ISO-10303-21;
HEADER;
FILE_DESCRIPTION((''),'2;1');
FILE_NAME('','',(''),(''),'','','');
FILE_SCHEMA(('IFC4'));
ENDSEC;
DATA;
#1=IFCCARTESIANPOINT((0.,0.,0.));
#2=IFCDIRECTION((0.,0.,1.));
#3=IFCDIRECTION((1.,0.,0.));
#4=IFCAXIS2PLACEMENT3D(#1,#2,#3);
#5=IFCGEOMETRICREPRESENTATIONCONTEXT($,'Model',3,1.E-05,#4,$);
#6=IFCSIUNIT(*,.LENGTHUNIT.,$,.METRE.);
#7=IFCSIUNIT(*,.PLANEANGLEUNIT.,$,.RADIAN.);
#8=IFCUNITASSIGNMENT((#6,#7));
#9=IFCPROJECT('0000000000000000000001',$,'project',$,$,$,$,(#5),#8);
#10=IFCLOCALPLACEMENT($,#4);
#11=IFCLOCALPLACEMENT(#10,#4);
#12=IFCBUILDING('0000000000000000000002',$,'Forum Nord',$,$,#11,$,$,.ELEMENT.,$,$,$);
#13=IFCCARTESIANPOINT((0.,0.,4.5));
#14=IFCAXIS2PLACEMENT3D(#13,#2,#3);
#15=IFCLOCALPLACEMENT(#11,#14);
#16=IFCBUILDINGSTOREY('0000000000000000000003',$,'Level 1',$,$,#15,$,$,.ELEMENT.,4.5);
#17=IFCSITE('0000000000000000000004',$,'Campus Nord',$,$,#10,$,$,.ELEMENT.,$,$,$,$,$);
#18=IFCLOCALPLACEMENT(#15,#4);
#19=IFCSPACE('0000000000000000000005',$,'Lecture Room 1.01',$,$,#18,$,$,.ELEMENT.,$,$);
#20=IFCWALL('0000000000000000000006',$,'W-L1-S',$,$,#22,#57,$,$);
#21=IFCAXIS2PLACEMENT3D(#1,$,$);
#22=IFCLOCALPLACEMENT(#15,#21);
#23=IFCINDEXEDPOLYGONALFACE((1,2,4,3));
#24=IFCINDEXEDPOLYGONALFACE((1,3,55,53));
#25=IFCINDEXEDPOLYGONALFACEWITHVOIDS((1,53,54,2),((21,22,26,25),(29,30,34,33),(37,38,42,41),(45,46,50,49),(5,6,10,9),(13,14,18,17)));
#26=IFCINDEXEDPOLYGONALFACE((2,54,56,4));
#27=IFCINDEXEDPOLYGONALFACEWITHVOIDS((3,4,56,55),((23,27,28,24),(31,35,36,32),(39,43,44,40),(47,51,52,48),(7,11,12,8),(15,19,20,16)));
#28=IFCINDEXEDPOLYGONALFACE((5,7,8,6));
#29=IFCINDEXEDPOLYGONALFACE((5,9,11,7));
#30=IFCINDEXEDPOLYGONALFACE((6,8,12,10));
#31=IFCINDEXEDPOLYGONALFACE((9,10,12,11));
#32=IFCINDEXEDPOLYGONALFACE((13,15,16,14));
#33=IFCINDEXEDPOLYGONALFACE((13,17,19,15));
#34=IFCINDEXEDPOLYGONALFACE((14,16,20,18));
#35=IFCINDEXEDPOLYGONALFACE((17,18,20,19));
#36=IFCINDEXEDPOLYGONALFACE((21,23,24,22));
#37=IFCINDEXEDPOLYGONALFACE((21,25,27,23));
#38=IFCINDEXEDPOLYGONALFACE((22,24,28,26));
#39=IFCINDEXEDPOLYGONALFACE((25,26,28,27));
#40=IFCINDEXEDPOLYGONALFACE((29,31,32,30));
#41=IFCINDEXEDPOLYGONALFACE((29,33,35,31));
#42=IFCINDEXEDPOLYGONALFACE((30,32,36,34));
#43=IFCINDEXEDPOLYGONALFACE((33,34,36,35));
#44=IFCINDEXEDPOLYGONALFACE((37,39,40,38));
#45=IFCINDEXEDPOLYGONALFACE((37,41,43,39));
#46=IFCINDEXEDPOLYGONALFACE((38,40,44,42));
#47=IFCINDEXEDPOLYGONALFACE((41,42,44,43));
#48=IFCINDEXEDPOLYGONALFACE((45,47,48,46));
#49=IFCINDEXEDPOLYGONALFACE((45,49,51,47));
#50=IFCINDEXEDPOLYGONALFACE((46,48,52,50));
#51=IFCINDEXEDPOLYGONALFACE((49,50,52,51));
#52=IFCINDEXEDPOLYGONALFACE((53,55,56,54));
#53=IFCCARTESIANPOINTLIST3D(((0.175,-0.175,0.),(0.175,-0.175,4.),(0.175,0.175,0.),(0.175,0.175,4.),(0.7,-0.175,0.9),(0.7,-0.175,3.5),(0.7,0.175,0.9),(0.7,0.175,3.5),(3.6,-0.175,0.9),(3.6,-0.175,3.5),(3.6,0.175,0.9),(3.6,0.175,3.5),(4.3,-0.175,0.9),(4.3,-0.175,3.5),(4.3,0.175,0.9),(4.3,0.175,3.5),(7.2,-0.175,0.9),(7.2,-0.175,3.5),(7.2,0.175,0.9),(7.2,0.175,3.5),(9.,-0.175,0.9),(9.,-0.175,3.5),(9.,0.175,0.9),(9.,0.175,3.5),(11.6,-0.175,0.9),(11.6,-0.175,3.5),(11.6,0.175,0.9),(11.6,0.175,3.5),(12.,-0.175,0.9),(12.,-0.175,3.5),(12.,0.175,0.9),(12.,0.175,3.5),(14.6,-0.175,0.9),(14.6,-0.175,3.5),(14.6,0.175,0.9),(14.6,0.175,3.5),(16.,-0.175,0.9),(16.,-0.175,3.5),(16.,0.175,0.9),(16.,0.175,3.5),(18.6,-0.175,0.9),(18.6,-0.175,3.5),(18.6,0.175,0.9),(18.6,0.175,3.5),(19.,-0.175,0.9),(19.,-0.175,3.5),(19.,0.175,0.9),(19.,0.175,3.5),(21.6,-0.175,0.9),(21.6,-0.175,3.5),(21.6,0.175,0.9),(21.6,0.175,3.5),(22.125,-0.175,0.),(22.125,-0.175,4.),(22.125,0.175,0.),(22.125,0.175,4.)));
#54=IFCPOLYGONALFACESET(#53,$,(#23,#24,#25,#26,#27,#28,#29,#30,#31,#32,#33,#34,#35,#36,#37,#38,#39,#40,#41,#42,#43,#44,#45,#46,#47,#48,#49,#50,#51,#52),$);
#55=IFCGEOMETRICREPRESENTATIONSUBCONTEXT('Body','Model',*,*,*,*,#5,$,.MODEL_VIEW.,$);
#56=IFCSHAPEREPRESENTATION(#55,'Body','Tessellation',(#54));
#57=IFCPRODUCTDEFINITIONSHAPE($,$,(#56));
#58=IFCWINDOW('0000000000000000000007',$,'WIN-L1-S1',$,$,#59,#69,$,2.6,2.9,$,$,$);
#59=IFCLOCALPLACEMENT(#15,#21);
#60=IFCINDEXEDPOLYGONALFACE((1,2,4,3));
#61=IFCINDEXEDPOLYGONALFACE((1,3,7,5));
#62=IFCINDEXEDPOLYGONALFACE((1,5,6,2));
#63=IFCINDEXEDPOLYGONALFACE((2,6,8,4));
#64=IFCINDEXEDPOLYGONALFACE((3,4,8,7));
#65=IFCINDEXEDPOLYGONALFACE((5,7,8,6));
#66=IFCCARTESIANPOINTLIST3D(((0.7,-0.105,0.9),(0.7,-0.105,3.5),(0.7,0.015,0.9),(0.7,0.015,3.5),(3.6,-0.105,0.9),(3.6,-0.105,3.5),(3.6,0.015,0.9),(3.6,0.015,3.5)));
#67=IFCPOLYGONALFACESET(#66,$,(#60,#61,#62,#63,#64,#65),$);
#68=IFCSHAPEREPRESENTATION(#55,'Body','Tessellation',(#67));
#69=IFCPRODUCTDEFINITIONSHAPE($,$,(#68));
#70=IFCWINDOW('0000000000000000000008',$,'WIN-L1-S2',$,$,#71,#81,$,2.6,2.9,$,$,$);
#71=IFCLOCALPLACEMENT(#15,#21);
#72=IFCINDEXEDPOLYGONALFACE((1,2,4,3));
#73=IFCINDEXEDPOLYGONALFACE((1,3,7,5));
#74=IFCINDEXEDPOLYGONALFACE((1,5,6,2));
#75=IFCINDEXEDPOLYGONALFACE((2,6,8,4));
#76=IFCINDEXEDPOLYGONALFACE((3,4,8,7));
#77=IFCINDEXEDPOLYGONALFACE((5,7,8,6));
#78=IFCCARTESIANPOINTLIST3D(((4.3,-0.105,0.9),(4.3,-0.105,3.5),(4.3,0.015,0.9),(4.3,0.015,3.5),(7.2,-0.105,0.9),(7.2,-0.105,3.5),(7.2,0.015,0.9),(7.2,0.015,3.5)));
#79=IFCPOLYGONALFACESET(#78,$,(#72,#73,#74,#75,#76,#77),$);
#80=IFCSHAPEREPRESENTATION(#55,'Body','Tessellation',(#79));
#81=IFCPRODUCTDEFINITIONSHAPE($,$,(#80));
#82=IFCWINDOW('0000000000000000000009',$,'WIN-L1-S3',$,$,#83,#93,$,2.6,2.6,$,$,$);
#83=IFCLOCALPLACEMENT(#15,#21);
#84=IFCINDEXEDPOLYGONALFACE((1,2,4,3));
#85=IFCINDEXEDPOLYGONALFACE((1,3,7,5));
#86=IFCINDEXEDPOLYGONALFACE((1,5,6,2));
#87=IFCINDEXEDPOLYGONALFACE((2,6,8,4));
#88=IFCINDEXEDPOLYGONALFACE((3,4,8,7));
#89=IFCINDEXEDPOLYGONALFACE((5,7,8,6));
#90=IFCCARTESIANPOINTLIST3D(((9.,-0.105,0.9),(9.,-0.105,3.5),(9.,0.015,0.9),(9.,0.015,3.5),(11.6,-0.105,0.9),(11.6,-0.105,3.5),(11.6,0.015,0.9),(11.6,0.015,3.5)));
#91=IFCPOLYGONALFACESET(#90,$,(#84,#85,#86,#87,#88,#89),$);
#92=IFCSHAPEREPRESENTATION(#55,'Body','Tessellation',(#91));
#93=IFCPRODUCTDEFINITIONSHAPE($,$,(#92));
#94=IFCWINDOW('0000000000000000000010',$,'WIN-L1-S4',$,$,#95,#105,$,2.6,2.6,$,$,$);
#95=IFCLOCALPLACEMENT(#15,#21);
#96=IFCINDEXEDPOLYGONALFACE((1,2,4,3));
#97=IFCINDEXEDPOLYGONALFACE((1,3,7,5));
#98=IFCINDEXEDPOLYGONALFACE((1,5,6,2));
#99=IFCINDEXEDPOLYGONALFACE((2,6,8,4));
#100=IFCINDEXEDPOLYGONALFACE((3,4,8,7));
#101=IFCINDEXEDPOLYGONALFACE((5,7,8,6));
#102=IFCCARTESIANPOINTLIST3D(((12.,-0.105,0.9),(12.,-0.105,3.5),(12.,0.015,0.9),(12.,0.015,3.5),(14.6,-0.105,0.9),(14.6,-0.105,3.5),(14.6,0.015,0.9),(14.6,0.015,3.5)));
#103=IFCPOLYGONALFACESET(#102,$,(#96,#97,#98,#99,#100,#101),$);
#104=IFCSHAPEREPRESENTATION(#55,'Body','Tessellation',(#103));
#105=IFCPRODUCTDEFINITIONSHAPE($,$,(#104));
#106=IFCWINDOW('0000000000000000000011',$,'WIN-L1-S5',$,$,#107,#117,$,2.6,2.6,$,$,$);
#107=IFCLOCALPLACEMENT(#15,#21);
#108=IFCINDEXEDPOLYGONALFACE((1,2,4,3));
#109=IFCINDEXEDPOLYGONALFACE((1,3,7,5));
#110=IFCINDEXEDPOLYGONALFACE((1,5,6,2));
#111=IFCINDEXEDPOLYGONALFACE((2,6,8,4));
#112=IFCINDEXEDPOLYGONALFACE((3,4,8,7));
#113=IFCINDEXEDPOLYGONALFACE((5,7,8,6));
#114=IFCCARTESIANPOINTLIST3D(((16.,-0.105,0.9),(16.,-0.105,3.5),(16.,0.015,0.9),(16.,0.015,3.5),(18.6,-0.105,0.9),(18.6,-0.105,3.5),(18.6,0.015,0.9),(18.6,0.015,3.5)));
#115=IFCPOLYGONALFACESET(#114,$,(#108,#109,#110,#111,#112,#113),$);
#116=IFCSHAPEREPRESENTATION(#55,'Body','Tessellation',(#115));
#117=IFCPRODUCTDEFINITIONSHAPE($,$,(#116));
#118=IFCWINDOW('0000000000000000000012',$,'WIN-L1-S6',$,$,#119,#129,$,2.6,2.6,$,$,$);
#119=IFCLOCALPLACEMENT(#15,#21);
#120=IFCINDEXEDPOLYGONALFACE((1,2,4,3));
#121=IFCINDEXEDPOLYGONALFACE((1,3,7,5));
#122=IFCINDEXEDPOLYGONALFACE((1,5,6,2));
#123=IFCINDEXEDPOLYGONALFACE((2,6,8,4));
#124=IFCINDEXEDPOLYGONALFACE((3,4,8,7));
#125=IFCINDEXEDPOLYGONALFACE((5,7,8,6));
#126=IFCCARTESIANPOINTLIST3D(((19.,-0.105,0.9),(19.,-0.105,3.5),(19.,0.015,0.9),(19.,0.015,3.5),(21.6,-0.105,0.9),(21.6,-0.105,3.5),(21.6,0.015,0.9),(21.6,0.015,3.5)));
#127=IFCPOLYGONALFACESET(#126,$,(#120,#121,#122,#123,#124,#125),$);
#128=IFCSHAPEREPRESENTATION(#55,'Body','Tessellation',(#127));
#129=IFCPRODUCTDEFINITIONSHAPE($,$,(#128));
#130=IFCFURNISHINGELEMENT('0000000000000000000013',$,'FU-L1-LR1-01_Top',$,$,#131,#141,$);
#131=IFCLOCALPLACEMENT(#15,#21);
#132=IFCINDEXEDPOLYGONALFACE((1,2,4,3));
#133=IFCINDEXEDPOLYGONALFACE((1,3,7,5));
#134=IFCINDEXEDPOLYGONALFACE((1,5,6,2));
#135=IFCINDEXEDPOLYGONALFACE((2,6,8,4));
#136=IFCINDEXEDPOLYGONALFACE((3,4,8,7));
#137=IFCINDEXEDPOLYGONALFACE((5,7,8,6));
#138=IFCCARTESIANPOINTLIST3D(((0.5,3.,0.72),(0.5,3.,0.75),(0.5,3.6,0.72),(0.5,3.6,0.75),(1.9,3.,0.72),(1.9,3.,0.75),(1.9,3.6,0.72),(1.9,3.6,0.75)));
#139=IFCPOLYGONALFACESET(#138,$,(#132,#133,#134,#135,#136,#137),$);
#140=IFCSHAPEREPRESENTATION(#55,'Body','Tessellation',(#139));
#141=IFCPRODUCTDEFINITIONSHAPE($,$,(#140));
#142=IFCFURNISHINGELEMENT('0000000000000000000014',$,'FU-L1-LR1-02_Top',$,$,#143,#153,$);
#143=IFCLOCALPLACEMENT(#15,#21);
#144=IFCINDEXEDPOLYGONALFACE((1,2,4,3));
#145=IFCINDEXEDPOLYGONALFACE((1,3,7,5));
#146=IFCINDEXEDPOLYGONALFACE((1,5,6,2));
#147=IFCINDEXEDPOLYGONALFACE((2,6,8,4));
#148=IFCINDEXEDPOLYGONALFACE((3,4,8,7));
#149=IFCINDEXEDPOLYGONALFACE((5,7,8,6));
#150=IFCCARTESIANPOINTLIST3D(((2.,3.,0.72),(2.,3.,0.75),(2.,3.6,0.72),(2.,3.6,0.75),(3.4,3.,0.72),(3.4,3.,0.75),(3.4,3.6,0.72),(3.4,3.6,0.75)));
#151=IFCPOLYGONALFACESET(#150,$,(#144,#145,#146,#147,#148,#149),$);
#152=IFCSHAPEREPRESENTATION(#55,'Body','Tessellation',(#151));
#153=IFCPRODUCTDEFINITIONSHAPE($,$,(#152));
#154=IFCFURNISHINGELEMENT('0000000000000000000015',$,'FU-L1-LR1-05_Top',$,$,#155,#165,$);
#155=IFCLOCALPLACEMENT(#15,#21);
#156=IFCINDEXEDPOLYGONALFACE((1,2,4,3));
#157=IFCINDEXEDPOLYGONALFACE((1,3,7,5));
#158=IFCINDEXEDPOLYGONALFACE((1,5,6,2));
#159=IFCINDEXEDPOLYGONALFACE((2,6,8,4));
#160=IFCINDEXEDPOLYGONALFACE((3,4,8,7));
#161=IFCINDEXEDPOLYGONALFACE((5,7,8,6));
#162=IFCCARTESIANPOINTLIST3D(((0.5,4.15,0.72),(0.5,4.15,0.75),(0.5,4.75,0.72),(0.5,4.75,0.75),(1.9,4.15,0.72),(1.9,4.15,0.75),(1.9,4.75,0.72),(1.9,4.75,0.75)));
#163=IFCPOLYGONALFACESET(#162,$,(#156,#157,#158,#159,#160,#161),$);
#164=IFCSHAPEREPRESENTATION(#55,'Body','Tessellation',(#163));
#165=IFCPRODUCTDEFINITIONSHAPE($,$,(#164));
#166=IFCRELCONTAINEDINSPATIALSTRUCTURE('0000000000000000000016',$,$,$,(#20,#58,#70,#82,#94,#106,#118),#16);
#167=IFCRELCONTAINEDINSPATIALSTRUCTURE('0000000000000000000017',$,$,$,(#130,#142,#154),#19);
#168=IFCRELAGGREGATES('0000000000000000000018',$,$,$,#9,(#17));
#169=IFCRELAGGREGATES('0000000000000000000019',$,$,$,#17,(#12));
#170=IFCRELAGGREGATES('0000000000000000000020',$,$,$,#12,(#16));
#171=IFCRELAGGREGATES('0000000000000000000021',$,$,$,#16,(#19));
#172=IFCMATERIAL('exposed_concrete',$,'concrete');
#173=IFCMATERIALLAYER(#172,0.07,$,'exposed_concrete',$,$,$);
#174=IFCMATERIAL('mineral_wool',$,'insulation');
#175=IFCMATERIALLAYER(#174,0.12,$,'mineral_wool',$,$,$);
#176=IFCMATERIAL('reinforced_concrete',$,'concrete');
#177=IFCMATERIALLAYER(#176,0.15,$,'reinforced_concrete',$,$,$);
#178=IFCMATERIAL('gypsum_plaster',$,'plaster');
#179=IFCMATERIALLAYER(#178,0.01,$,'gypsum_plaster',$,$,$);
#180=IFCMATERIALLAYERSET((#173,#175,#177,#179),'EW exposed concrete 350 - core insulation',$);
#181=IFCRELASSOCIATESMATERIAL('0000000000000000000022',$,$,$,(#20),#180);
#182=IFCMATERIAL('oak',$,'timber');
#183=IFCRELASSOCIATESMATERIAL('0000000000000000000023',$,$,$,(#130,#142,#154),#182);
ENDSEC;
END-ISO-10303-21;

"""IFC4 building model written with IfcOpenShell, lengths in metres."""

from ifc_helpers import new_model, si_unit, frame, frame_2d, origin_with_axes, place, context, subcontext, project, spatial, rectangle, extrude, material, layer, layer_set, layer_usage, element, fill, save


model = new_model("IFC4")

# Units and contexts
model_context = context("Model", 3, precision=1e-05, world=origin_with_axes())
body_context = subcontext(model_context, "Body", "Model", "MODEL_VIEW")
ifc_project = project(units=[si_unit("LENGTHUNIT", "METRE"), si_unit("PLANEANGLEUNIT", "RADIAN")], contexts=[model_context])

# Site, building, storey
site_placement = place(None, origin_with_axes())
site = spatial("IfcSite", under=ifc_project, at=site_placement, Name="Campus Nord", CompositionType="ELEMENT")
building_placement = place(site_placement, origin_with_axes())
building = spatial("IfcBuilding", under=site, at=building_placement, Name="Forum Nord", CompositionType="ELEMENT")
storey_placement = place(building_placement, frame((0.0, 0.0, 4.5), z_axis=(0.0, 0.0, 1.0), x_axis=(1.0, 0.0, 0.0)))
storey = spatial("IfcBuildingStorey", under=building, at=storey_placement, Name="Level 1", CompositionType="ELEMENT", Elevation=4.5)

# Shared definitions
ifc_material_1 = material(Name="exposed_concrete", Category="concrete")

# Wall, openings, windows
ifc_layer_1 = layer(ifc_material_1, 0.07, Name="exposed_concrete")
ifc_material_2 = material(Name="mineral_wool", Category="insulation")
ifc_layer_2 = layer(ifc_material_2, 0.12, Name="mineral_wool")
ifc_material_3 = material(Name="reinforced_concrete", Category="concrete")
ifc_layer_3 = layer(ifc_material_3, 0.15, Name="reinforced_concrete")
ifc_material_4 = material(Name="gypsum_plaster", Category="plaster")
ifc_layer_4 = layer(ifc_material_4, 0.01, Name="gypsum_plaster")
ifc_layer_set = layer_set([ifc_layer_1, ifc_layer_2, ifc_layer_3, ifc_layer_4], Name="EW exposed concrete 350 - core insulation")
ifc_layer_usage = layer_usage(ifc_layer_set, "AXIS2", "POSITIVE", -0.175)
wall_placement = place(storey_placement, frame((0.175, 0.0, 0.0), z_axis=(0.0, 0.0, 1.0), x_axis=(1.0, 0.0, 0.0)))
wall = element("IfcWall", 1, at=wall_placement, inside=storey, material=ifc_layer_usage, Name="W-L1-S", context=body_context, shape_type="SweptSolid", body=[
    extrude(rectangle(XDim=21.95, YDim=0.35, at=frame_2d((10.975, 0.0), x_axis=(1.0, 0.0))), origin_with_axes(), (0.0, 0.0, 1.0), 4.0),
])
opening_1_placement = place(storey_placement, frame((0.175, 0.0, 0.0), z_axis=(0.0, 0.0, 1.0), x_axis=(1.0, 0.0, 0.0)))
opening_1 = element("IfcOpeningElement", 2, at=opening_1_placement, cuts=wall, context=body_context, shape_type="SweptSolid", body=[
    extrude(rectangle(XDim=2.9, YDim=0.35, at=frame_2d((1.975, 0.0), x_axis=(1.0, 0.0))), frame((0.0, 0.0, 0.9), z_axis=(0.0, 0.0, 1.0), x_axis=(1.0, 0.0, 0.0)), (0.0, 0.0, 1.0), 2.6),
])
opening_2_placement = place(storey_placement, frame((0.175, 0.0, 0.0), z_axis=(0.0, 0.0, 1.0), x_axis=(1.0, 0.0, 0.0)))
opening_2 = element("IfcOpeningElement", 3, at=opening_2_placement, cuts=wall, context=body_context, shape_type="SweptSolid", body=[
    extrude(rectangle(XDim=2.9, YDim=0.35, at=frame_2d((5.575, 0.0), x_axis=(1.0, 0.0))), frame((0.0, 0.0, 0.9), z_axis=(0.0, 0.0, 1.0), x_axis=(1.0, 0.0, 0.0)), (0.0, 0.0, 1.0), 2.6),
])
opening_3_placement = place(storey_placement, frame((0.175, 0.0, 0.0), z_axis=(0.0, 0.0, 1.0), x_axis=(1.0, 0.0, 0.0)))
opening_3 = element("IfcOpeningElement", 4, at=opening_3_placement, cuts=wall, context=body_context, shape_type="SweptSolid", body=[
    extrude(rectangle(XDim=2.6, YDim=0.35, at=frame_2d((10.125, 0.0), x_axis=(1.0, 0.0))), frame((0.0, 0.0, 0.9), z_axis=(0.0, 0.0, 1.0), x_axis=(1.0, 0.0, 0.0)), (0.0, 0.0, 1.0), 2.6),
])
opening_4_placement = place(storey_placement, frame((0.175, 0.0, 0.0), z_axis=(0.0, 0.0, 1.0), x_axis=(1.0, 0.0, 0.0)))
opening_4 = element("IfcOpeningElement", 5, at=opening_4_placement, cuts=wall, context=body_context, shape_type="SweptSolid", body=[
    extrude(rectangle(XDim=2.6, YDim=0.35, at=frame_2d((13.125, 0.0), x_axis=(1.0, 0.0))), frame((0.0, 0.0, 0.9), z_axis=(0.0, 0.0, 1.0), x_axis=(1.0, 0.0, 0.0)), (0.0, 0.0, 1.0), 2.6),
])
opening_5_placement = place(storey_placement, frame((0.175, 0.0, 0.0), z_axis=(0.0, 0.0, 1.0), x_axis=(1.0, 0.0, 0.0)))
opening_5 = element("IfcOpeningElement", 6, at=opening_5_placement, cuts=wall, context=body_context, shape_type="SweptSolid", body=[
    extrude(rectangle(XDim=2.6, YDim=0.35, at=frame_2d((17.125, 0.0), x_axis=(1.0, 0.0))), frame((0.0, 0.0, 0.9), z_axis=(0.0, 0.0, 1.0), x_axis=(1.0, 0.0, 0.0)), (0.0, 0.0, 1.0), 2.6),
])
opening_6_placement = place(storey_placement, frame((0.175, 0.0, 0.0), z_axis=(0.0, 0.0, 1.0), x_axis=(1.0, 0.0, 0.0)))
opening_6 = element("IfcOpeningElement", 7, at=opening_6_placement, cuts=wall, context=body_context, shape_type="SweptSolid", body=[
    extrude(rectangle(XDim=2.6, YDim=0.35, at=frame_2d((20.125, 0.0), x_axis=(1.0, 0.0))), frame((0.0, 0.0, 0.9), z_axis=(0.0, 0.0, 1.0), x_axis=(1.0, 0.0, 0.0)), (0.0, 0.0, 1.0), 2.6),
])
window_1_placement = place(storey_placement, frame((0.175, 0.0, 0.0), z_axis=(0.0, 0.0, 1.0), x_axis=(1.0, 0.0, 0.0)))
window_1 = element("IfcWindow", 8, at=window_1_placement, inside=storey, Name="WIN-L1-S1", OverallHeight=2.6, OverallWidth=2.9, context=body_context, shape_type="SweptSolid", body=[
    extrude(rectangle(XDim=2.9, YDim=0.12, at=frame_2d((1.975, -0.045), x_axis=(1.0, 0.0))), frame((0.0, 0.0, 0.9), z_axis=(0.0, 0.0, 1.0), x_axis=(1.0, 0.0, 0.0)), (0.0, 0.0, 1.0), 2.6),
])
fill(opening_1, window_1)
window_2_placement = place(storey_placement, frame((0.175, 0.0, 0.0), z_axis=(0.0, 0.0, 1.0), x_axis=(1.0, 0.0, 0.0)))
window_2 = element("IfcWindow", 9, at=window_2_placement, inside=storey, Name="WIN-L1-S2", OverallHeight=2.6, OverallWidth=2.9, context=body_context, shape_type="SweptSolid", body=[
    extrude(rectangle(XDim=2.9, YDim=0.12, at=frame_2d((5.575, -0.045), x_axis=(1.0, 0.0))), frame((0.0, 0.0, 0.9), z_axis=(0.0, 0.0, 1.0), x_axis=(1.0, 0.0, 0.0)), (0.0, 0.0, 1.0), 2.6),
])
fill(opening_2, window_2)
window_3_placement = place(storey_placement, frame((0.175, 0.0, 0.0), z_axis=(0.0, 0.0, 1.0), x_axis=(1.0, 0.0, 0.0)))
window_3 = element("IfcWindow", 10, at=window_3_placement, inside=storey, Name="WIN-L1-S3", OverallHeight=2.6, OverallWidth=2.6, context=body_context, shape_type="SweptSolid", body=[
    extrude(rectangle(XDim=2.6, YDim=0.12, at=frame_2d((10.125, -0.045), x_axis=(1.0, 0.0))), frame((0.0, 0.0, 0.9), z_axis=(0.0, 0.0, 1.0), x_axis=(1.0, 0.0, 0.0)), (0.0, 0.0, 1.0), 2.6),
])
fill(opening_3, window_3)
window_4_placement = place(storey_placement, frame((0.175, 0.0, 0.0), z_axis=(0.0, 0.0, 1.0), x_axis=(1.0, 0.0, 0.0)))
window_4 = element("IfcWindow", 11, at=window_4_placement, inside=storey, Name="WIN-L1-S4", OverallHeight=2.6, OverallWidth=2.6, context=body_context, shape_type="SweptSolid", body=[
    extrude(rectangle(XDim=2.6, YDim=0.12, at=frame_2d((13.125, -0.045), x_axis=(1.0, 0.0))), frame((0.0, 0.0, 0.9), z_axis=(0.0, 0.0, 1.0), x_axis=(1.0, 0.0, 0.0)), (0.0, 0.0, 1.0), 2.6),
])
fill(opening_4, window_4)
window_5_placement = place(storey_placement, frame((0.175, 0.0, 0.0), z_axis=(0.0, 0.0, 1.0), x_axis=(1.0, 0.0, 0.0)))
window_5 = element("IfcWindow", 12, at=window_5_placement, inside=storey, Name="WIN-L1-S5", OverallHeight=2.6, OverallWidth=2.6, context=body_context, shape_type="SweptSolid", body=[
    extrude(rectangle(XDim=2.6, YDim=0.12, at=frame_2d((17.125, -0.045), x_axis=(1.0, 0.0))), frame((0.0, 0.0, 0.9), z_axis=(0.0, 0.0, 1.0), x_axis=(1.0, 0.0, 0.0)), (0.0, 0.0, 1.0), 2.6),
])
fill(opening_5, window_5)
window_6_placement = place(storey_placement, frame((0.175, 0.0, 0.0), z_axis=(0.0, 0.0, 1.0), x_axis=(1.0, 0.0, 0.0)))
window_6 = element("IfcWindow", 13, at=window_6_placement, inside=storey, Name="WIN-L1-S6", OverallHeight=2.6, OverallWidth=2.6, context=body_context, shape_type="SweptSolid", body=[
    extrude(rectangle(XDim=2.6, YDim=0.12, at=frame_2d((20.125, -0.045), x_axis=(1.0, 0.0))), frame((0.0, 0.0, 0.9), z_axis=(0.0, 0.0, 1.0), x_axis=(1.0, 0.0, 0.0)), (0.0, 0.0, 1.0), 2.6),
])
fill(opening_6, window_6)

# Shared definitions
space_placement = place(storey_placement, origin_with_axes())
space = spatial("IfcSpace", under=storey, at=space_placement, Name="Lecture Room 1.01", CompositionType="ELEMENT")

# Furnishing elements
ifc_material_5 = material(Name="oak", Category="timber")
furnishing_1_placement = place(storey_placement, frame((0.5, 3.0, 0.0), z_axis=(0.0, 0.0, 1.0), x_axis=(1.0, 0.0, 0.0)))
element("IfcFurnishingElement", 14, at=furnishing_1_placement, inside=space, material=ifc_material_5, Name="FU-L1-LR1-01_Top", context=body_context, shape_type="SweptSolid", body=[
    extrude(rectangle(XDim=1.4, YDim=0.6, at=frame_2d((0.7, 0.3), x_axis=(1.0, 0.0))), frame((0.0, 0.0, 0.72), z_axis=(0.0, 0.0, 1.0), x_axis=(1.0, 0.0, 0.0)), (0.0, 0.0, 1.0), 0.03),
])
furnishing_2_placement = place(storey_placement, frame((2.0, 3.0, 0.0), z_axis=(0.0, 0.0, 1.0), x_axis=(1.0, 0.0, 0.0)))
element("IfcFurnishingElement", 15, at=furnishing_2_placement, inside=space, material=ifc_material_5, Name="FU-L1-LR1-02_Top", context=body_context, shape_type="SweptSolid", body=[
    extrude(rectangle(XDim=1.4, YDim=0.6, at=frame_2d((0.7, 0.3), x_axis=(1.0, 0.0))), frame((0.0, 0.0, 0.72), z_axis=(0.0, 0.0, 1.0), x_axis=(1.0, 0.0, 0.0)), (0.0, 0.0, 1.0), 0.03),
])
furnishing_3_placement = place(storey_placement, frame((0.5, 4.15, 0.0), z_axis=(0.0, 0.0, 1.0), x_axis=(1.0, 0.0, 0.0)))
element("IfcFurnishingElement", 16, at=furnishing_3_placement, inside=space, material=ifc_material_5, Name="FU-L1-LR1-05_Top", context=body_context, shape_type="SweptSolid", body=[
    extrude(rectangle(XDim=1.4, YDim=0.6, at=frame_2d((0.7, 0.3), x_axis=(1.0, 0.0))), frame((0.0, 0.0, 0.72), z_axis=(0.0, 0.0, 1.0), x_axis=(1.0, 0.0, 0.0)), (0.0, 0.0, 1.0), 0.03),
])

save(model, "model.ifc")
